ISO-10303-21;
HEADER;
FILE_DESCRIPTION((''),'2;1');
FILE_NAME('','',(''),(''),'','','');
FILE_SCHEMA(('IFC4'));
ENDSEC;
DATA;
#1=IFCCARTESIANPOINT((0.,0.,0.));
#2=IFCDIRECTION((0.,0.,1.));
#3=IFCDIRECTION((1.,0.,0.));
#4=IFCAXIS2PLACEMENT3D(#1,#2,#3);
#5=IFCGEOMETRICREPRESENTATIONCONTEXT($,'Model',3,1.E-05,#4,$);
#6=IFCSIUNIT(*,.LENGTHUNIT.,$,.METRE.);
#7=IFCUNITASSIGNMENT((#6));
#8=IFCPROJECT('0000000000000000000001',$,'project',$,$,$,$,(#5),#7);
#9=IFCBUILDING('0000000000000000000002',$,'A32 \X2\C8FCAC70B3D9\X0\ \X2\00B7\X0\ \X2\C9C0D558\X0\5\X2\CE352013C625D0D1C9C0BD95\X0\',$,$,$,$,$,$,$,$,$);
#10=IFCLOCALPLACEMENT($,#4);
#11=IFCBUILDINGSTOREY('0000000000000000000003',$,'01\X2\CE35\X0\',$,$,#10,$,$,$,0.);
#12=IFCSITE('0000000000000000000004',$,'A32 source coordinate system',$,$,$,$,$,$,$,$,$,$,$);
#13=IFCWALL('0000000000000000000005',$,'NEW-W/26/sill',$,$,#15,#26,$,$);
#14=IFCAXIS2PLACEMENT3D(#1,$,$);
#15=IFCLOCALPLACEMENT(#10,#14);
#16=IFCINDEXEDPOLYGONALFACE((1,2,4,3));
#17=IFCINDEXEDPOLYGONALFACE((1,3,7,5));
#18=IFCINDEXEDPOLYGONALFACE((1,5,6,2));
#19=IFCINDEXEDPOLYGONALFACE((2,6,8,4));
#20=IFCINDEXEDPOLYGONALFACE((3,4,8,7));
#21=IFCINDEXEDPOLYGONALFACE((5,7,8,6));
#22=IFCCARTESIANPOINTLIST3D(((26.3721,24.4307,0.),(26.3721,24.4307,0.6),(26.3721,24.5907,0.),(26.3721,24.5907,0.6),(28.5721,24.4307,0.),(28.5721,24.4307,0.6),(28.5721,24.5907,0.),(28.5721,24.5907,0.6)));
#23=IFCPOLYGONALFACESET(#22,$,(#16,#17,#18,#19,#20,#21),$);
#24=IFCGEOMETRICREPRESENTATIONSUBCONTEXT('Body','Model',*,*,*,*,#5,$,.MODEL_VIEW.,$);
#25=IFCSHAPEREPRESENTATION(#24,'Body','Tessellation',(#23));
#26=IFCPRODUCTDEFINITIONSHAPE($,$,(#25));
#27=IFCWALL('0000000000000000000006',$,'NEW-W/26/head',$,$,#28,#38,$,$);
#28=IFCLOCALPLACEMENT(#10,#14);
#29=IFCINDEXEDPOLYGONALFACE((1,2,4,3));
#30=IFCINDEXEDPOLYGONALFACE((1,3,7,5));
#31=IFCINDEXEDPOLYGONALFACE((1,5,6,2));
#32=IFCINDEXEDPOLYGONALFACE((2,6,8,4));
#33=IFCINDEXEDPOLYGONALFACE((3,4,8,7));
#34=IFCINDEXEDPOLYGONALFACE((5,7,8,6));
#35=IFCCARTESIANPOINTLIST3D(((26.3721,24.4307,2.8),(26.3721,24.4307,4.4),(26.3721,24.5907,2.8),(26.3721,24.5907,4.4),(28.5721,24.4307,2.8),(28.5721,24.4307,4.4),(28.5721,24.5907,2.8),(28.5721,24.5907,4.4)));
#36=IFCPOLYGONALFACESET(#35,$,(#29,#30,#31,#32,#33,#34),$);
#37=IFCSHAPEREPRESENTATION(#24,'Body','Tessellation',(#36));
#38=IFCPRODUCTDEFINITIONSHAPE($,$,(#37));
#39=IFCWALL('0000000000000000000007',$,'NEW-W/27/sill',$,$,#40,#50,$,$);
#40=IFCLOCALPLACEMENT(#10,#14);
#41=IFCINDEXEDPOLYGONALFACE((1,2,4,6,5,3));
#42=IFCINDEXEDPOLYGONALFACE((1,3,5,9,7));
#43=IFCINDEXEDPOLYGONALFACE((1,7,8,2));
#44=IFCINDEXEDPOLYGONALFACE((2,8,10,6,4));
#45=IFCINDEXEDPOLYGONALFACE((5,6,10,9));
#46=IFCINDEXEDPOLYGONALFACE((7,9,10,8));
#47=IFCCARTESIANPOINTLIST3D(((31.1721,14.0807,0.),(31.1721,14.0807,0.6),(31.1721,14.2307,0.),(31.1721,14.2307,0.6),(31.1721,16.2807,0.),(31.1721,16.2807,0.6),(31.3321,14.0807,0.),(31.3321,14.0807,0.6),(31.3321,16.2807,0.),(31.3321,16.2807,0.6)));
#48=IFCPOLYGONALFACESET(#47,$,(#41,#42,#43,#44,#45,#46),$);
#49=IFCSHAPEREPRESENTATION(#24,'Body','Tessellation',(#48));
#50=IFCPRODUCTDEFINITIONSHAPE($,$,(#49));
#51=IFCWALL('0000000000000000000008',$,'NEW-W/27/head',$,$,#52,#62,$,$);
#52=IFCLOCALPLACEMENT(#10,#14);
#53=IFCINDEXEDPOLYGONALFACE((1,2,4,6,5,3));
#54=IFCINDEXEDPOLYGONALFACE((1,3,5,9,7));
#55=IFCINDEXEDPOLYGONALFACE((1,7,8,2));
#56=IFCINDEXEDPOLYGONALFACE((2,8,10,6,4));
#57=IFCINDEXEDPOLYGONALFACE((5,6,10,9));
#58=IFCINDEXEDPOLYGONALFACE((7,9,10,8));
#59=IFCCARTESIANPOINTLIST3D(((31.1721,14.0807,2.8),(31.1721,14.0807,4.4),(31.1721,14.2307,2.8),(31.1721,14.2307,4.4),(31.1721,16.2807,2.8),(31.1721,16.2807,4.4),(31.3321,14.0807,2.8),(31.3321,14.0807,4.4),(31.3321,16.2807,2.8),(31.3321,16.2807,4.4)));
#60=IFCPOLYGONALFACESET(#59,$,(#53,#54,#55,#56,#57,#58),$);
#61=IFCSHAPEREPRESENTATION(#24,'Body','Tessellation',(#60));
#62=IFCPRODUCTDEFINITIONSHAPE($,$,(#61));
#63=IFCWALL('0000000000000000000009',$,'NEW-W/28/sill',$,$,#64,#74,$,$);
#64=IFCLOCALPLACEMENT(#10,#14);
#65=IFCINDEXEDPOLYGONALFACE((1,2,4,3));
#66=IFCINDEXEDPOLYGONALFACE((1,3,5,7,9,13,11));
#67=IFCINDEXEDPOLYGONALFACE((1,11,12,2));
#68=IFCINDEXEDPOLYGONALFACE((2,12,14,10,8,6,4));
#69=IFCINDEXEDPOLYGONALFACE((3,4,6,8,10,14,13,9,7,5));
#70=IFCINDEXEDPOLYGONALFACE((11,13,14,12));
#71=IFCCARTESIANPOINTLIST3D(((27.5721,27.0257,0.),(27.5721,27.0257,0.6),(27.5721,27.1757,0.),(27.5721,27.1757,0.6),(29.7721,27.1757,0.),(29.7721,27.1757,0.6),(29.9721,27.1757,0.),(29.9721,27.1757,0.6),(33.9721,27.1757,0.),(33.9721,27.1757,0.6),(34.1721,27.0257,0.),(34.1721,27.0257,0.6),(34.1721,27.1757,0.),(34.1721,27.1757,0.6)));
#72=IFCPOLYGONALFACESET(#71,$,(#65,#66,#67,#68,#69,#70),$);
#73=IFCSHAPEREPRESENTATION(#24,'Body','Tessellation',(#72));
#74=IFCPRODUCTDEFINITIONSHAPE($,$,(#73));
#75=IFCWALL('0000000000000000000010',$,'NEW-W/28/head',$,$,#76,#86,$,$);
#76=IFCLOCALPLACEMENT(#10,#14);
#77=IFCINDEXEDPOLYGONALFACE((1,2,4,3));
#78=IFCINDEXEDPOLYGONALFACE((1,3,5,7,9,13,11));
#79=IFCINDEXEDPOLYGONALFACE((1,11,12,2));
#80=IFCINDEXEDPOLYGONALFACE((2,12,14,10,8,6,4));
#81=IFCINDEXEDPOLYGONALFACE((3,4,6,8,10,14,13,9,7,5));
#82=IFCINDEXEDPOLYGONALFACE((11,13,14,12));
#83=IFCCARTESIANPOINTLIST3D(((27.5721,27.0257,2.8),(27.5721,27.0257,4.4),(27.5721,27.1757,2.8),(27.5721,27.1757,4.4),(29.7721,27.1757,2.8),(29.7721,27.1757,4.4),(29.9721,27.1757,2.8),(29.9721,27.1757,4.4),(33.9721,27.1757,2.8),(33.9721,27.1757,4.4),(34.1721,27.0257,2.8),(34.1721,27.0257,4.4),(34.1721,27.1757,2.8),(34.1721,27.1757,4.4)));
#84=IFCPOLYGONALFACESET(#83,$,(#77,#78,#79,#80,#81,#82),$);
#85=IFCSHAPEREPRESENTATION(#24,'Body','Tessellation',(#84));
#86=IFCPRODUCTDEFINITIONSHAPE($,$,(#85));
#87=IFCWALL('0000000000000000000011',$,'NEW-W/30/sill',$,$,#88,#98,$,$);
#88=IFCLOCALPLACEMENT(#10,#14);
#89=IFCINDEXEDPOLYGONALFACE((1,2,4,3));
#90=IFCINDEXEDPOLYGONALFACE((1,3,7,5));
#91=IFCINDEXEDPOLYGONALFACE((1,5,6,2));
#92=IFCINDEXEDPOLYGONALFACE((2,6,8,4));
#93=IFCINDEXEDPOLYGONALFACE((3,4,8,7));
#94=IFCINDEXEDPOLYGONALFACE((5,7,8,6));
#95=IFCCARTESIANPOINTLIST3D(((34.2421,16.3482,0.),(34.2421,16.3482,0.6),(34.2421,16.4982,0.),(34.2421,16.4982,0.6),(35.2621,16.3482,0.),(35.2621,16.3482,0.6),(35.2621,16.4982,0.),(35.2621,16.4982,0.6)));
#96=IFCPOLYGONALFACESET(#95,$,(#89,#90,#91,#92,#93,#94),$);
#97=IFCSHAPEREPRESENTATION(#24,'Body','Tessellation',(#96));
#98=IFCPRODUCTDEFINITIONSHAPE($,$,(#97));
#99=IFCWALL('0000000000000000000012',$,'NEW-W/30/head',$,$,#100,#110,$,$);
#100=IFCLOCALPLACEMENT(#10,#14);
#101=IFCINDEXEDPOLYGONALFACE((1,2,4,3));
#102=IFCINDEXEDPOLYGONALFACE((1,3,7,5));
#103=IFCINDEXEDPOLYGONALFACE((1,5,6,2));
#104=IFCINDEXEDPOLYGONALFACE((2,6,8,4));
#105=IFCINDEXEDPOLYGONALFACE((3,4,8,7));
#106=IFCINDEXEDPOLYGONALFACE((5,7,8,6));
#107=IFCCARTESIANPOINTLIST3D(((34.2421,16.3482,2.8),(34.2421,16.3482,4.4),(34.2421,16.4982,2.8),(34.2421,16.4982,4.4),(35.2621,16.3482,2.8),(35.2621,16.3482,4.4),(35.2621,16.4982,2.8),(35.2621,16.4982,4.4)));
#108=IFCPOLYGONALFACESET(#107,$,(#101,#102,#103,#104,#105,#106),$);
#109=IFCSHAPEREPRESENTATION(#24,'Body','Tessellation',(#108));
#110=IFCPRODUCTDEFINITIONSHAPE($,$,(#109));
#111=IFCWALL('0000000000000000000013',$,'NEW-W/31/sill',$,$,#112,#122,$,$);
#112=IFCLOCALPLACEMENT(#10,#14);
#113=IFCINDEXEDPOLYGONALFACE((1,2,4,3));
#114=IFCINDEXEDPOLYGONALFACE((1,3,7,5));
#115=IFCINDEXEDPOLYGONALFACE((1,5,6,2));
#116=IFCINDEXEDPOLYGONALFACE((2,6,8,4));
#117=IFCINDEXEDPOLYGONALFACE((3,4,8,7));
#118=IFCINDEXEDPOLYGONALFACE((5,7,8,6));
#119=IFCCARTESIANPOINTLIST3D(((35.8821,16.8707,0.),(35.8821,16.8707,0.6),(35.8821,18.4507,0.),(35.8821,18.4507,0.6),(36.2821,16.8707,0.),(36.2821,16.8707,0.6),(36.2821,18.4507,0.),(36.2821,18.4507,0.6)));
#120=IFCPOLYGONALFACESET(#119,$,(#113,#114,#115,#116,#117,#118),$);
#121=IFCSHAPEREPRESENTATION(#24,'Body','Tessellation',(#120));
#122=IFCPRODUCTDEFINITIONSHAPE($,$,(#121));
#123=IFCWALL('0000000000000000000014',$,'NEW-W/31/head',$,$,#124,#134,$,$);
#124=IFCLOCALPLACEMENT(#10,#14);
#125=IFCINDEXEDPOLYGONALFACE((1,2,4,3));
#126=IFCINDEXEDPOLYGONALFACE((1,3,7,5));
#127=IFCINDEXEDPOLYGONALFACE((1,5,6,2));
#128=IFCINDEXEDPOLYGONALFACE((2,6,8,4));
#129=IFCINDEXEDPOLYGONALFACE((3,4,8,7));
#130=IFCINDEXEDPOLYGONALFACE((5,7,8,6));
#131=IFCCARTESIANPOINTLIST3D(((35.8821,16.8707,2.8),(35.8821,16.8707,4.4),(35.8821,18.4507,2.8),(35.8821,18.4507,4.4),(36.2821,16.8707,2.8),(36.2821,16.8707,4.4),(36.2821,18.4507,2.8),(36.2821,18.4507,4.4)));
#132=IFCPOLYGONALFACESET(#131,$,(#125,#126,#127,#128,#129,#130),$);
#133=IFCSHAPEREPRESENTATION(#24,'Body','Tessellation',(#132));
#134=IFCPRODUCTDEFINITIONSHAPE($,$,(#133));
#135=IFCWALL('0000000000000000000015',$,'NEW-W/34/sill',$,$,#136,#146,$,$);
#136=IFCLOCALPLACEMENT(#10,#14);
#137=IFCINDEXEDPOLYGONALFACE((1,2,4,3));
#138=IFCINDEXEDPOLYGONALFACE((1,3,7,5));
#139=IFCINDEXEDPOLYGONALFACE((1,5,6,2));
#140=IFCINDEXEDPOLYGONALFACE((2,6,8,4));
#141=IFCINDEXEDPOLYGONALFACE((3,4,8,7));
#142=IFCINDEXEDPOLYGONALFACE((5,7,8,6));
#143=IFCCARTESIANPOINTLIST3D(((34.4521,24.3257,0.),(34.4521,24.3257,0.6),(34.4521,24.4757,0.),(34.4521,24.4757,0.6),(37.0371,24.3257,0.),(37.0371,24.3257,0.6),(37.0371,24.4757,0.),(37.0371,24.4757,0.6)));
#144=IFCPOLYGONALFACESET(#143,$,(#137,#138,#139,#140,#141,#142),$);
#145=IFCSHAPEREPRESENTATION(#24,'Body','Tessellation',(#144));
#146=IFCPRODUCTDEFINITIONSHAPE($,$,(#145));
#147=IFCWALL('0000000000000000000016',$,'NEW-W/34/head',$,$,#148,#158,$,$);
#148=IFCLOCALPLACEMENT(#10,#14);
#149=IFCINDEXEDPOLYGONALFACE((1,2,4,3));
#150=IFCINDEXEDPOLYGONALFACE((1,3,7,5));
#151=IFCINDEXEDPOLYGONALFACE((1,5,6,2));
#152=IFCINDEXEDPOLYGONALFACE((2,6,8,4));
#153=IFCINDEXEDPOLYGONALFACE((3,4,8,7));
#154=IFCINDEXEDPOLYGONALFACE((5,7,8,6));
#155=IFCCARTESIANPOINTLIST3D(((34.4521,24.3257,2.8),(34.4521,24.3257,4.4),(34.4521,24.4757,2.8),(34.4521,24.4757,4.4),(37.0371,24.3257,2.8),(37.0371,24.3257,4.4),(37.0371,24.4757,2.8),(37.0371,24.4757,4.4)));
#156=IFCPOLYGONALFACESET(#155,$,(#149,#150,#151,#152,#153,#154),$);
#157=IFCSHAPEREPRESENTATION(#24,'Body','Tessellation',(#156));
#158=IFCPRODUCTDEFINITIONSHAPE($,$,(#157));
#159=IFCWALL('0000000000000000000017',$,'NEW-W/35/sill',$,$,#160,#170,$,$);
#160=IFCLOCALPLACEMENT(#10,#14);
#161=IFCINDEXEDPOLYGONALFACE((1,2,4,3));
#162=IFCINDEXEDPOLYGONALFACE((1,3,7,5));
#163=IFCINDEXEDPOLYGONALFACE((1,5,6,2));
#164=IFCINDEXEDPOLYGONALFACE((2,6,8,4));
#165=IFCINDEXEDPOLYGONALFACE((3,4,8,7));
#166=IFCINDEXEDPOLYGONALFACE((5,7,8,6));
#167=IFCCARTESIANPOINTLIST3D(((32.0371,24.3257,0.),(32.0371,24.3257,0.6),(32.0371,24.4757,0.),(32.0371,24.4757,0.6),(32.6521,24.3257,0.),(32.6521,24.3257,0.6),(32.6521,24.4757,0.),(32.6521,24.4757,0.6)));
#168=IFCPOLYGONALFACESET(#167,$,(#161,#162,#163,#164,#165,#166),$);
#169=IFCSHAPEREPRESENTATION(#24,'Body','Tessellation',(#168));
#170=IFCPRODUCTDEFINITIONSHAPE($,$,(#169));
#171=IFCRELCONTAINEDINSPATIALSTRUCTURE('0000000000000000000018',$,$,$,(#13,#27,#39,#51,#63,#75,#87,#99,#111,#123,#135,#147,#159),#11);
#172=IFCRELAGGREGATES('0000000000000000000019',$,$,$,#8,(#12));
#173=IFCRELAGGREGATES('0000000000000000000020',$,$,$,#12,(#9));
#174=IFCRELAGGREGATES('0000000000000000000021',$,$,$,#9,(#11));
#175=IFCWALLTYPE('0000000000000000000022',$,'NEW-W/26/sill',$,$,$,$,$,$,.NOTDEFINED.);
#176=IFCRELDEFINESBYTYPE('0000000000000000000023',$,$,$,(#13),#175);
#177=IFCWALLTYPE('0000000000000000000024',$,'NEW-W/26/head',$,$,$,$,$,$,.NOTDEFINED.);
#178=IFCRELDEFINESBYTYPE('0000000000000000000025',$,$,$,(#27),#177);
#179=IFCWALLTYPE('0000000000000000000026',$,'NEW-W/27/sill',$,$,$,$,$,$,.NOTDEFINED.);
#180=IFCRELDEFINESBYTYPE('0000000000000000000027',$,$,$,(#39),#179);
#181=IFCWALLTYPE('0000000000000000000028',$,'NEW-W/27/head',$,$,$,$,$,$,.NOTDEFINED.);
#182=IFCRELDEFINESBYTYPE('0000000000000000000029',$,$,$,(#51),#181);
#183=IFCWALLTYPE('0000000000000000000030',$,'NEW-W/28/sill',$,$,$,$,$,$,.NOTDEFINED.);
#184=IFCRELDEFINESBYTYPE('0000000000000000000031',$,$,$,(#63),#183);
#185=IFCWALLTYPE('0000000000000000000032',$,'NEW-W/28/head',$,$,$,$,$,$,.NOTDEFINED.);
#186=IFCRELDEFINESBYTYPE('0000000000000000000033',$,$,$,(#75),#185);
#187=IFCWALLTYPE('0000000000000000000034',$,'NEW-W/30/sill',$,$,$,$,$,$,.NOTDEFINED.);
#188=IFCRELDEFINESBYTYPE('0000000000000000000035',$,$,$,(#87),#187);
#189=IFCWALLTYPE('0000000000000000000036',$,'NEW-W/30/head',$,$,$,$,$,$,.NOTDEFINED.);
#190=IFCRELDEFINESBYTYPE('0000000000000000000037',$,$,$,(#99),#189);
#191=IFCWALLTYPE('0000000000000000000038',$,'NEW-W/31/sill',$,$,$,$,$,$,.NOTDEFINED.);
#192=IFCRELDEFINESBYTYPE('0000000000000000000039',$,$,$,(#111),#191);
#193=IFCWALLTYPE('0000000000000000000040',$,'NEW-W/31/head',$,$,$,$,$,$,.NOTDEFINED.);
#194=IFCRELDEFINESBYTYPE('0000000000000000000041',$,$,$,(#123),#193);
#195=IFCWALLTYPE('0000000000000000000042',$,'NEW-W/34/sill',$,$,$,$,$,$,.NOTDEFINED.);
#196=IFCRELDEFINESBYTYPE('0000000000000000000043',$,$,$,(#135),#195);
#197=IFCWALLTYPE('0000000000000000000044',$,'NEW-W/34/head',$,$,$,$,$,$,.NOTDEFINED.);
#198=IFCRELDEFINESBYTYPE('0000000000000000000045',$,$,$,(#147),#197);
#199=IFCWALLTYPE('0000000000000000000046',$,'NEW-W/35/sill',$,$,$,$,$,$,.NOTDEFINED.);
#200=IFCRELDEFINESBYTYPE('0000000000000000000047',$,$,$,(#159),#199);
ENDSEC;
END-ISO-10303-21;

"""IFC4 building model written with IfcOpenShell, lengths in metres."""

from ifc_helpers import new_model, si_unit, frame, origin, origin_with_axes, place, context, subcontext, project, spatial, polyline, outline, extrude, source, transform, mapped, type_object, type_shapes, element, save


model = new_model("IFC4")

# Units and contexts
model_context = context("Model", 3, precision=1e-05, world=origin_with_axes())
body_context = subcontext(model_context, "Body", "Model", "MODEL_VIEW")
ifc_project = project(units=[si_unit("LENGTHUNIT", "METRE")], contexts=[model_context])

# Site, building, storey
site = spatial("IfcSite", under=ifc_project, Name="A32 source coordinate system")
building = spatial("IfcBuilding", under=site, Name="A32 주거동 · 지하5층–옥탑지붕")
storey_placement = place(None, origin_with_axes())
storey = spatial("IfcBuildingStorey", under=building, at=storey_placement, Name="01층", Elevation=0.0)

# Walls
wall_type_1 = type_object("IfcWallType", Name="NEW-W/26/sill", PredefinedType="NOTDEFINED")
shared_shape_1 = source(origin(), body_context, "Body", "SweptSolid", [
    extrude(outline(polyline([(26.3721, 24.4307), (26.3721, 24.5907), (28.5721, 24.5907), (28.5721, 24.4307), (26.3721, 24.4307)])), origin(), (0.0, 0.0, 1.0), 0.6),
])
type_shapes(wall_type_1, [shared_shape_1])
wall_1_placement = place(storey_placement, origin_with_axes())
element("IfcWall", 1, at=wall_1_placement, inside=storey, type_object=wall_type_1, Name="NEW-W/26/sill", context=body_context, shape_type="MappedRepresentation", body=[
    mapped(shared_shape_1, transform((0.0, 0.0, 0.0), scale=1.0)),
])
wall_type_2 = type_object("IfcWallType", Name="NEW-W/26/head", PredefinedType="NOTDEFINED")
shared_shape_2 = source(origin(), body_context, "Body", "SweptSolid", [
    extrude(outline(polyline([(26.3721, 24.4307), (26.3721, 24.5907), (28.5721, 24.5907), (28.5721, 24.4307), (26.3721, 24.4307)])), frame((0.0, 0.0, 2.8)), (0.0, 0.0, 1.0), 1.6),
])
type_shapes(wall_type_2, [shared_shape_2])
wall_2_placement = place(storey_placement, origin_with_axes())
element("IfcWall", 2, at=wall_2_placement, inside=storey, type_object=wall_type_2, Name="NEW-W/26/head", context=body_context, shape_type="MappedRepresentation", body=[
    mapped(shared_shape_2, transform((0.0, 0.0, 0.0), scale=1.0)),
])
wall_type_3 = type_object("IfcWallType", Name="NEW-W/27/sill", PredefinedType="NOTDEFINED")
shared_shape_3 = source(origin(), body_context, "Body", "SweptSolid", [
    extrude(outline(polyline([(31.1721, 16.2807), (31.3321, 16.2807), (31.3321, 14.0807), (31.1721, 14.0807), (31.1721, 14.2307), (31.1721, 14.2307), (31.1721, 16.2807)])), origin(), (0.0, 0.0, 1.0), 0.6),
])
type_shapes(wall_type_3, [shared_shape_3])
wall_3_placement = place(storey_placement, origin_with_axes())
element("IfcWall", 3, at=wall_3_placement, inside=storey, type_object=wall_type_3, Name="NEW-W/27/sill", context=body_context, shape_type="MappedRepresentation", body=[
    mapped(shared_shape_3, transform((0.0, 0.0, 0.0), scale=1.0)),
])
wall_type_4 = type_object("IfcWallType", Name="NEW-W/27/head", PredefinedType="NOTDEFINED")
shared_shape_4 = source(origin(), body_context, "Body", "SweptSolid", [
    extrude(outline(polyline([(31.1721, 16.2807), (31.3321, 16.2807), (31.3321, 14.0807), (31.1721, 14.0807), (31.1721, 14.2307), (31.1721, 14.2307), (31.1721, 16.2807)])), frame((0.0, 0.0, 2.8)), (0.0, 0.0, 1.0), 1.6),
])
type_shapes(wall_type_4, [shared_shape_4])
wall_4_placement = place(storey_placement, origin_with_axes())
element("IfcWall", 4, at=wall_4_placement, inside=storey, type_object=wall_type_4, Name="NEW-W/27/head", context=body_context, shape_type="MappedRepresentation", body=[
    mapped(shared_shape_4, transform((0.0, 0.0, 0.0), scale=1.0)),
])
wall_type_5 = type_object("IfcWallType", Name="NEW-W/28/sill", PredefinedType="NOTDEFINED")
shared_shape_5 = source(origin(), body_context, "Body", "SweptSolid", [
    extrude(outline(polyline([(34.1721, 27.0257), (27.5721, 27.0257), (27.5721, 27.1757), (29.7721, 27.1757), (29.7721, 27.1757), (29.9721, 27.1757), (29.9721, 27.1757), (33.9721, 27.1757), (33.9721, 27.1757), (34.1721, 27.1757), (34.1721, 27.0257)])), origin(), (0.0, 0.0, 1.0), 0.6),
])
type_shapes(wall_type_5, [shared_shape_5])
wall_5_placement = place(storey_placement, origin_with_axes())
element("IfcWall", 5, at=wall_5_placement, inside=storey, type_object=wall_type_5, Name="NEW-W/28/sill", context=body_context, shape_type="MappedRepresentation", body=[
    mapped(shared_shape_5, transform((0.0, 0.0, 0.0), scale=1.0)),
])
wall_type_6 = type_object("IfcWallType", Name="NEW-W/28/head", PredefinedType="NOTDEFINED")
shared_shape_6 = source(origin(), body_context, "Body", "SweptSolid", [
    extrude(outline(polyline([(34.1721, 27.0257), (27.5721, 27.0257), (27.5721, 27.1757), (29.7721, 27.1757), (29.7721, 27.1757), (29.9721, 27.1757), (29.9721, 27.1757), (33.9721, 27.1757), (33.9721, 27.1757), (34.1721, 27.1757), (34.1721, 27.0257)])), frame((0.0, 0.0, 2.8)), (0.0, 0.0, 1.0), 1.6),
])
type_shapes(wall_type_6, [shared_shape_6])
wall_6_placement = place(storey_placement, origin_with_axes())
element("IfcWall", 6, at=wall_6_placement, inside=storey, type_object=wall_type_6, Name="NEW-W/28/head", context=body_context, shape_type="MappedRepresentation", body=[
    mapped(shared_shape_6, transform((0.0, 0.0, 0.0), scale=1.0)),
])
wall_type_7 = type_object("IfcWallType", Name="NEW-W/30/sill", PredefinedType="NOTDEFINED")
shared_shape_7 = source(origin(), body_context, "Body", "SweptSolid", [
    extrude(outline(polyline([(34.2421, 16.3482), (34.2421, 16.4982), (35.2621, 16.4982), (35.2621, 16.3482), (34.2421, 16.3482)])), origin(), (0.0, 0.0, 1.0), 0.6),
])
type_shapes(wall_type_7, [shared_shape_7])
wall_7_placement = place(storey_placement, origin_with_axes())
element("IfcWall", 7, at=wall_7_placement, inside=storey, type_object=wall_type_7, Name="NEW-W/30/sill", context=body_context, shape_type="MappedRepresentation", body=[
    mapped(shared_shape_7, transform((0.0, 0.0, 0.0), scale=1.0)),
])
wall_type_8 = type_object("IfcWallType", Name="NEW-W/30/head", PredefinedType="NOTDEFINED")
shared_shape_8 = source(origin(), body_context, "Body", "SweptSolid", [
    extrude(outline(polyline([(34.2421, 16.3482), (34.2421, 16.4982), (35.2621, 16.4982), (35.2621, 16.3482), (34.2421, 16.3482)])), frame((0.0, 0.0, 2.8)), (0.0, 0.0, 1.0), 1.6),
])
type_shapes(wall_type_8, [shared_shape_8])
wall_8_placement = place(storey_placement, origin_with_axes())
element("IfcWall", 8, at=wall_8_placement, inside=storey, type_object=wall_type_8, Name="NEW-W/30/head", context=body_context, shape_type="MappedRepresentation", body=[
    mapped(shared_shape_8, transform((0.0, 0.0, 0.0), scale=1.0)),
])
wall_type_9 = type_object("IfcWallType", Name="NEW-W/31/sill", PredefinedType="NOTDEFINED")
shared_shape_9 = source(origin(), body_context, "Body", "SweptSolid", [
    extrude(outline(polyline([(35.8821, 16.8707), (35.8821, 18.4507), (36.2821, 18.4507), (36.2821, 16.8707), (35.8821, 16.8707)])), origin(), (0.0, 0.0, 1.0), 0.6),
])
type_shapes(wall_type_9, [shared_shape_9])
wall_9_placement = place(storey_placement, origin_with_axes())
element("IfcWall", 9, at=wall_9_placement, inside=storey, type_object=wall_type_9, Name="NEW-W/31/sill", context=body_context, shape_type="MappedRepresentation", body=[
    mapped(shared_shape_9, transform((0.0, 0.0, 0.0), scale=1.0)),
])
wall_type_10 = type_object("IfcWallType", Name="NEW-W/31/head", PredefinedType="NOTDEFINED")
shared_shape_10 = source(origin(), body_context, "Body", "SweptSolid", [
    extrude(outline(polyline([(35.8821, 16.8707), (35.8821, 18.4507), (36.2821, 18.4507), (36.2821, 16.8707), (35.8821, 16.8707)])), frame((0.0, 0.0, 2.8)), (0.0, 0.0, 1.0), 1.6),
])
type_shapes(wall_type_10, [shared_shape_10])
wall_10_placement = place(storey_placement, origin_with_axes())
element("IfcWall", 10, at=wall_10_placement, inside=storey, type_object=wall_type_10, Name="NEW-W/31/head", context=body_context, shape_type="MappedRepresentation", body=[
    mapped(shared_shape_10, transform((0.0, 0.0, 0.0), scale=1.0)),
])
wall_type_11 = type_object("IfcWallType", Name="NEW-W/34/sill", PredefinedType="NOTDEFINED")
shared_shape_11 = source(origin(), body_context, "Body", "SweptSolid", [
    extrude(outline(polyline([(34.4521, 24.3257), (34.4521, 24.4757), (37.0371, 24.4757), (37.0371, 24.3257), (34.4521, 24.3257)])), origin(), (0.0, 0.0, 1.0), 0.6),
])
type_shapes(wall_type_11, [shared_shape_11])
wall_11_placement = place(storey_placement, origin_with_axes())
element("IfcWall", 11, at=wall_11_placement, inside=storey, type_object=wall_type_11, Name="NEW-W/34/sill", context=body_context, shape_type="MappedRepresentation", body=[
    mapped(shared_shape_11, transform((0.0, 0.0, 0.0), scale=1.0)),
])
wall_type_12 = type_object("IfcWallType", Name="NEW-W/34/head", PredefinedType="NOTDEFINED")
shared_shape_12 = source(origin(), body_context, "Body", "SweptSolid", [
    extrude(outline(polyline([(34.4521, 24.3257), (34.4521, 24.4757), (37.0371, 24.4757), (37.0371, 24.3257), (34.4521, 24.3257)])), frame((0.0, 0.0, 2.8)), (0.0, 0.0, 1.0), 1.6),
])
type_shapes(wall_type_12, [shared_shape_12])
wall_12_placement = place(storey_placement, origin_with_axes())
element("IfcWall", 12, at=wall_12_placement, inside=storey, type_object=wall_type_12, Name="NEW-W/34/head", context=body_context, shape_type="MappedRepresentation", body=[
    mapped(shared_shape_12, transform((0.0, 0.0, 0.0), scale=1.0)),
])
wall_type_13 = type_object("IfcWallType", Name="NEW-W/35/sill", PredefinedType="NOTDEFINED")
shared_shape_13 = source(origin(), body_context, "Body", "SweptSolid", [
    extrude(outline(polyline([(32.0371, 24.3257), (32.0371, 24.4757), (32.6521, 24.4757), (32.6521, 24.3257), (32.0371, 24.3257)])), origin(), (0.0, 0.0, 1.0), 0.6),
])
type_shapes(wall_type_13, [shared_shape_13])
wall_13_placement = place(storey_placement, origin_with_axes())
element("IfcWall", 13, at=wall_13_placement, inside=storey, type_object=wall_type_13, Name="NEW-W/35/sill", context=body_context, shape_type="MappedRepresentation", body=[
    mapped(shared_shape_13, transform((0.0, 0.0, 0.0), scale=1.0)),
])

save(model, "model.ifc")
